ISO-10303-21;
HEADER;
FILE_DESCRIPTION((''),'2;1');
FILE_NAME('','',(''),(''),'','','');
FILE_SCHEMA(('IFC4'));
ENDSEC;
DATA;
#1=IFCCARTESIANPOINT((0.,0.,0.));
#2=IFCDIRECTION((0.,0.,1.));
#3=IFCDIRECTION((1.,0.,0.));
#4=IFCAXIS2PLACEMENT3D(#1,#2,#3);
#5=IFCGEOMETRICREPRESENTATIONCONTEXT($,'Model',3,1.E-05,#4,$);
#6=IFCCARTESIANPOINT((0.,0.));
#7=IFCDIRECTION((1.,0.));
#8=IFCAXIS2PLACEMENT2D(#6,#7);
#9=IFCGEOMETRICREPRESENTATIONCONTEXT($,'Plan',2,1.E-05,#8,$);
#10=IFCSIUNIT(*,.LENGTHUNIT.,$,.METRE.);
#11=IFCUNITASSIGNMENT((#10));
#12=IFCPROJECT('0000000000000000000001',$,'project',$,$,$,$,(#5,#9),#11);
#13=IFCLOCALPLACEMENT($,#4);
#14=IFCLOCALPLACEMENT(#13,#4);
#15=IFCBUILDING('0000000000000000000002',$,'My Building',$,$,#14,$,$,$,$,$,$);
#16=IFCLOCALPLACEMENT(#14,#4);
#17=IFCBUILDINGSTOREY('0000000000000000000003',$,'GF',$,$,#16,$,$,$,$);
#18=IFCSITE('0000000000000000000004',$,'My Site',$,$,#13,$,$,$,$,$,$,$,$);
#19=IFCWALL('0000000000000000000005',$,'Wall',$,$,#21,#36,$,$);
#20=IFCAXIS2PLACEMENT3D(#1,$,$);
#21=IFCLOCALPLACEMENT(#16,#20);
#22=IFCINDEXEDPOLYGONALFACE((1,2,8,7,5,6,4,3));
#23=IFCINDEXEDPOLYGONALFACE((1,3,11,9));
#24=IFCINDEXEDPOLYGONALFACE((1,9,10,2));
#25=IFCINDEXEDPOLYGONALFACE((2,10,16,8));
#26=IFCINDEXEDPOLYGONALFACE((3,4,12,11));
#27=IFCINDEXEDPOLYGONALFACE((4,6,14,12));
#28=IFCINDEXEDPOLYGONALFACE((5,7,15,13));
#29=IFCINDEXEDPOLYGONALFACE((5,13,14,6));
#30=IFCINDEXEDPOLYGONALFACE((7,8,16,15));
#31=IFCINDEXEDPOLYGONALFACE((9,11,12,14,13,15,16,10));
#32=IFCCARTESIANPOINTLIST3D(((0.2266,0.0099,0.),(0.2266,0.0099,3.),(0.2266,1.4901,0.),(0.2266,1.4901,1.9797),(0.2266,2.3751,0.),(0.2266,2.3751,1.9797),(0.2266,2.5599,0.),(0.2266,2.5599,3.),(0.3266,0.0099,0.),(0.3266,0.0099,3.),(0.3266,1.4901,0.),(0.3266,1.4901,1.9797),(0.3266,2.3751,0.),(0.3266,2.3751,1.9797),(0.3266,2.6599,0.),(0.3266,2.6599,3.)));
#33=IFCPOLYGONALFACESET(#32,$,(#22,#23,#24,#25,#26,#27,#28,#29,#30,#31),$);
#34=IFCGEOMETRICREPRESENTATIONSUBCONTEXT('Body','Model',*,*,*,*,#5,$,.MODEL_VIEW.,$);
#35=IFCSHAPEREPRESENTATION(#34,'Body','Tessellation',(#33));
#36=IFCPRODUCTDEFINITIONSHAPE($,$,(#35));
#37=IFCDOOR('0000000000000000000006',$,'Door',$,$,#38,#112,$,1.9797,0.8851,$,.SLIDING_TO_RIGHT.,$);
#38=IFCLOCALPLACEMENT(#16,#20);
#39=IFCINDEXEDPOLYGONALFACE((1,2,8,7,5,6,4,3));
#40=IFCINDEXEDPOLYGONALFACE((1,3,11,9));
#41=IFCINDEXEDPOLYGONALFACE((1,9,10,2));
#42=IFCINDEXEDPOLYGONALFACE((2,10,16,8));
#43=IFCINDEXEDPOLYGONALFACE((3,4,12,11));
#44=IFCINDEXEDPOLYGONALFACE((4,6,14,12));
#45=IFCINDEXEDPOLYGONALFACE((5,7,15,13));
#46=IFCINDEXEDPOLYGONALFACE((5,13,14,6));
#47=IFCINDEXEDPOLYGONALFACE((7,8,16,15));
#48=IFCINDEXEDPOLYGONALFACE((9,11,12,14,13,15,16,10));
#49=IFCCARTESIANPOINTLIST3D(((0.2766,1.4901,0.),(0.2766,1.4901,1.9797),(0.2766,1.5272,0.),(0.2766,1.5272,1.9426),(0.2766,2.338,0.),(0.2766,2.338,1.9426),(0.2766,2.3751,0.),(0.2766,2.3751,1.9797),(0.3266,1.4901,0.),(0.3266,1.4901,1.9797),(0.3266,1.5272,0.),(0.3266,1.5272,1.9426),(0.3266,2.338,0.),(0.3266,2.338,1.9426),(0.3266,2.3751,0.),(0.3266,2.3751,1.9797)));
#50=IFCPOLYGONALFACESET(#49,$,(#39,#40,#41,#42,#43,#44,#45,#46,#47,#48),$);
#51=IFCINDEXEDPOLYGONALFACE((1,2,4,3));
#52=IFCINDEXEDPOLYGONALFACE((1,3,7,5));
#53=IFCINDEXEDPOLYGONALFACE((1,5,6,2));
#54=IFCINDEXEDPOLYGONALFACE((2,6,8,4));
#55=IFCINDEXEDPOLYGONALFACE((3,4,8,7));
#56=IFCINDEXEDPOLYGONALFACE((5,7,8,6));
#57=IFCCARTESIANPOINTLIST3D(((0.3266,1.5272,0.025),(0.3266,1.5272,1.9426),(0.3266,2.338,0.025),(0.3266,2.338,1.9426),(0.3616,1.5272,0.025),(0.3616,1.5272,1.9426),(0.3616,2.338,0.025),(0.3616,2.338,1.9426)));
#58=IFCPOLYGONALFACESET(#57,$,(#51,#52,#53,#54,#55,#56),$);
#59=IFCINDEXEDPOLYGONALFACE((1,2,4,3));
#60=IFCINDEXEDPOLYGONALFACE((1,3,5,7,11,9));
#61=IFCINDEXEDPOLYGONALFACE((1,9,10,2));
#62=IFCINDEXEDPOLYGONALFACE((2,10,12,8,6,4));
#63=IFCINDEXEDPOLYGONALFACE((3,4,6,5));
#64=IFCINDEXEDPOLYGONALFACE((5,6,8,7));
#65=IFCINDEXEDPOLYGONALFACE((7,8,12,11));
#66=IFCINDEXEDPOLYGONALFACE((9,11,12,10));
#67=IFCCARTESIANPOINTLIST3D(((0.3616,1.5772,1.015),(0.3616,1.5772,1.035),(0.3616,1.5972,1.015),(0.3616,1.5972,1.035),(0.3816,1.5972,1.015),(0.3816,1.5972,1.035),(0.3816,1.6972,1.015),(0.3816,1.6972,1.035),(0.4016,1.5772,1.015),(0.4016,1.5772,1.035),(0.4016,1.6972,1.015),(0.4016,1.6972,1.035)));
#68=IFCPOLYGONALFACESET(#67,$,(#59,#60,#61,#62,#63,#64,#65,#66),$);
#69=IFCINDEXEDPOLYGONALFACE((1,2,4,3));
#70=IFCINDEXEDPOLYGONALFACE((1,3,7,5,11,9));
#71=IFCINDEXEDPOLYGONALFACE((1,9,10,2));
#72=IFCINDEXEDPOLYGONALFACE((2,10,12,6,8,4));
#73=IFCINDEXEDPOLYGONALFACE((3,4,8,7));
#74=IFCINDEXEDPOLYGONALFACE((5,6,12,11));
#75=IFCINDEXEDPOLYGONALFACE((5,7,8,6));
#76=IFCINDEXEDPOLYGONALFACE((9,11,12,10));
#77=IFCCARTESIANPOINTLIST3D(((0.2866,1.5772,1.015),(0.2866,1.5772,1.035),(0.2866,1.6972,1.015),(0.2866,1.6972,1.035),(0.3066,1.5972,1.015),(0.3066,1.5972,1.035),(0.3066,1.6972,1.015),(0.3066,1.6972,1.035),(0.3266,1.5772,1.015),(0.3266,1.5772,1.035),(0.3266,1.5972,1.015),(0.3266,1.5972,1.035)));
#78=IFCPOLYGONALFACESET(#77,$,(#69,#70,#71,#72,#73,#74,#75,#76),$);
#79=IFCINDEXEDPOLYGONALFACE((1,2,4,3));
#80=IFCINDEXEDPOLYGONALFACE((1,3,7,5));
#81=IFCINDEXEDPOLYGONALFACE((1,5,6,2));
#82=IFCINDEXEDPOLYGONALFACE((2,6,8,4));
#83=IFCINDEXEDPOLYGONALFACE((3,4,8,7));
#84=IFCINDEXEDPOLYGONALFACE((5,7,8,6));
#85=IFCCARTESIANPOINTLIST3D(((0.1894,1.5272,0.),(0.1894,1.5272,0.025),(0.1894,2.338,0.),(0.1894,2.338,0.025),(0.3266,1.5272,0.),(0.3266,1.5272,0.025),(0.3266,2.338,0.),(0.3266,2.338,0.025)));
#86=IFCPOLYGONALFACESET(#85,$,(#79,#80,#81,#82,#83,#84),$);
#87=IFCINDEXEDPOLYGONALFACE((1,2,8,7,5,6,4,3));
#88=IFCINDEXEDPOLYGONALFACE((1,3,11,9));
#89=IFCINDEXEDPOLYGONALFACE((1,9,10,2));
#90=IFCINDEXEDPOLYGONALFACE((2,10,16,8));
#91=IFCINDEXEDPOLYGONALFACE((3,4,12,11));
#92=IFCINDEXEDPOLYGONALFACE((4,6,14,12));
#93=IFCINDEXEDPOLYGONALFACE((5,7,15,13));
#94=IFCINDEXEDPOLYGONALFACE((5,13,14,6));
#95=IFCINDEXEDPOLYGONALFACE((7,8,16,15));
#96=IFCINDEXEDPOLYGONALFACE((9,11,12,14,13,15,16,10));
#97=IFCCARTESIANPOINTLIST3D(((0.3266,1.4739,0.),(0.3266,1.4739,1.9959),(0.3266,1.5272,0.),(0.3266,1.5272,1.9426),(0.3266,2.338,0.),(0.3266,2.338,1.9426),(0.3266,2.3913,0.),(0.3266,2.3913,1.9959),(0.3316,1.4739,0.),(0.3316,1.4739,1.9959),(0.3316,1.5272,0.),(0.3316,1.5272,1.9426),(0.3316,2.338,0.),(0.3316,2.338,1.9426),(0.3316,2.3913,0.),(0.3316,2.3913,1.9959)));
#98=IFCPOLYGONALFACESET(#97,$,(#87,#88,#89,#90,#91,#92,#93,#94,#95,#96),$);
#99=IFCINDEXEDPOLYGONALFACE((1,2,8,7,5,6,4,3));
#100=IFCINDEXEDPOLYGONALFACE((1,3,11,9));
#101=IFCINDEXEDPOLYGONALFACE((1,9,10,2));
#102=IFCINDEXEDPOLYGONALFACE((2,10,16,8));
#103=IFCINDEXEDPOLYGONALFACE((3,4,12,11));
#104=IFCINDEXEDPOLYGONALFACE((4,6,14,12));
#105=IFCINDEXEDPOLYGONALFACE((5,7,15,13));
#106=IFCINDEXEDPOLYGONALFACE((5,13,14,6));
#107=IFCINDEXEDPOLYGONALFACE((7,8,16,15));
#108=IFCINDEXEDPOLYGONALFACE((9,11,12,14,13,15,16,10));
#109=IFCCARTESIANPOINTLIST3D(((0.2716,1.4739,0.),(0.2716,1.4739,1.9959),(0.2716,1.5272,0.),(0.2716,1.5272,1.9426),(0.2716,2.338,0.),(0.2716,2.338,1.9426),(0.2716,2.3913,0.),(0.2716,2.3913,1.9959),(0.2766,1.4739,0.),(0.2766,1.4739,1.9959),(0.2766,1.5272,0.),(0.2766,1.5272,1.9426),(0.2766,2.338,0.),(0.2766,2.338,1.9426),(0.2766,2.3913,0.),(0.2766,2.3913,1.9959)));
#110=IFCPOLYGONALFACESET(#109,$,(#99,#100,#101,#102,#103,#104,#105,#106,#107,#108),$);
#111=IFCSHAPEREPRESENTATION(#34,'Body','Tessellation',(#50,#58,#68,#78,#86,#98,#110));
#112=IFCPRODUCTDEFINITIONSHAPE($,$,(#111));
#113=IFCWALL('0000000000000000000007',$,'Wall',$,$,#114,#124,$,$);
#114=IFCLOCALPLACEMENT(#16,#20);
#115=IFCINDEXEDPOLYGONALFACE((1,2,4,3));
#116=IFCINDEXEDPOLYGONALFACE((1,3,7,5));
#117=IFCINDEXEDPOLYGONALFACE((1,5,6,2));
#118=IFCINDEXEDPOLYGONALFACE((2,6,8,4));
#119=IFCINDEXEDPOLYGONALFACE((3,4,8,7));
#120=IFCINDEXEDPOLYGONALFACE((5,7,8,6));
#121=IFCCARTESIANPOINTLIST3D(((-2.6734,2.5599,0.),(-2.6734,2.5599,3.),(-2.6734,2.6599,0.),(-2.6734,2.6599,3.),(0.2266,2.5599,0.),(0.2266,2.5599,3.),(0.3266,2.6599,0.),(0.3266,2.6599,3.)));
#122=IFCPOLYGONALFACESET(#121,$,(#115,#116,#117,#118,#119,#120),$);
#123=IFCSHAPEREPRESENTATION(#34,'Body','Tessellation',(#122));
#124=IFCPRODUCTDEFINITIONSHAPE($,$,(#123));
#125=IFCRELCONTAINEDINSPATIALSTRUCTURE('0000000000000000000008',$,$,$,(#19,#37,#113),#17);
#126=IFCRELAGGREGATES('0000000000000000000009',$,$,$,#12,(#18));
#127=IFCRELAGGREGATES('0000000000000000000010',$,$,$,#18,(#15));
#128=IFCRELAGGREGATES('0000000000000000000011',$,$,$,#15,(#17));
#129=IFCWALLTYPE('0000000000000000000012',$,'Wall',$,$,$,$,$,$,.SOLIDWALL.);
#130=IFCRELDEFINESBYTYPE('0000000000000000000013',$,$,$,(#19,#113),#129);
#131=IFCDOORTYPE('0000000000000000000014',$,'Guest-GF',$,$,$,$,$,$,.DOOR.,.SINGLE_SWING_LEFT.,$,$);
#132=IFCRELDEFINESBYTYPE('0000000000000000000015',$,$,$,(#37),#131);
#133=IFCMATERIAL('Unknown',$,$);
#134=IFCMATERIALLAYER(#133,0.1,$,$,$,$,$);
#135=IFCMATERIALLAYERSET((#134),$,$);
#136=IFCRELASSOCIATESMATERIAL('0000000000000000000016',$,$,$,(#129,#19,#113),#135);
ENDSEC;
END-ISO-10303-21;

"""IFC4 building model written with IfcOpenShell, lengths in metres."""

from ifc_helpers import new_model, entity, si_unit, frame, origin_with_axes, origin_2d_with_axis, place, context, subcontext, project, spatial, line, indexed_curve, outline, extrude, shape, source, transform, mapped, material, layer, layer_set, layer_usage, type_object, type_shapes, element, fill, save


model = new_model("IFC4")

# Units and contexts
model_context = context("Model", 3, precision=1e-05, world=origin_with_axes())
plan_context = context("Plan", 2, precision=1e-05, world=origin_2d_with_axis())
body_context_1 = subcontext(model_context, "Body", "Model", "MODEL_VIEW")
body_context_2 = subcontext(plan_context, "Body", "Plan", "PLAN_VIEW")
ifc_project = project(units=[si_unit("LENGTHUNIT", "METRE")], contexts=[model_context, plan_context])

# Site, building, storey
site_placement = place(None, origin_with_axes())
site = spatial("IfcSite", under=ifc_project, at=site_placement, Name="My Site")
building_placement = place(site_placement, origin_with_axes())
building = spatial("IfcBuilding", under=site, at=building_placement, Name="My Building")
storey_placement = place(building_placement, origin_with_axes())
storey = spatial("IfcBuildingStorey", under=building, at=storey_placement, Name="GF")

# Shared definitions
ifc_material = material(Name="Unknown")

# Shared definitions
ifc_layer_1 = layer(ifc_material, 0.1)
ifc_layer_set_1 = layer_set([ifc_layer_1])
wall_type = type_object("IfcWallType", Name="Wall", PredefinedType="SOLIDWALL", material=ifc_layer_set_1)

# Wall, opening, door
ifc_layer_usage_1 = layer_usage(ifc_layer_set_1, "AXIS2", "POSITIVE", 0.0)
wall_1_placement = place(storey_placement, frame((0.3266, 0.0099, 0.0), z_axis=(0.0, 0.0, 1.0), x_axis=(0.0, 1.0, 0.0)))
wall_1 = element("IfcWall", 1, at=wall_1_placement, inside=storey, type_object=wall_type, material=ifc_layer_usage_1, Name="Wall", context=body_context_1, shape_type="SweptSolid", body=[
    extrude(outline(indexed_curve([(0.0, 0.0), (0.0, 0.1), (2.55, 0.1), (2.65, 0.0)], segments=[line(1, 2, 3, 4, 1)])), origin_with_axes(), (0.0, 0.0, 1.0), 3.0),
])
shared_shape_1 = source(origin_with_axes(), body_context_1, "Body", "SweptSolid", [
    extrude(outline(indexed_curve([(0.0, 0.0), (0.8851, 0.0), (0.8851, 1.9797), (0.0, 1.9797)], segments=[line(1, 2, 3, 4, 1)])), frame((0.0, -0.6, 0.0), z_axis=(0.0, -1.0, 0.0), x_axis=(1.0, 0.0, 0.0)), (0.0, 0.0, -1.0), 1.2),
])
opening_1_placement = place(wall_1_placement, frame((1.4802, 0.0, 0.0), z_axis=(0.0, 0.0, 1.0), x_axis=(1.0, 0.0, 0.0)))
opening_1 = element("IfcOpeningElement", 2, at=opening_1_placement, cuts=wall_1, PredefinedType="OPENING", context=body_context_1, shape_type="MappedRepresentation", body=[
    mapped(shared_shape_1, transform((0.0, 0.0, 0.0), x_axis=(1.0, 0.0, 0.0), y_axis=(0.0, 1.0, 0.0), z_axis=(0.0, 0.0, 1.0), scale=1.0)),
])
door_type_1 = type_object("IfcDoorType", Name="Guest-GF", OperationType="SINGLE_SWING_LEFT", PredefinedType="DOOR")
shared_shape_2 = source(origin_with_axes(), body_context_1, "Body", "SweptSolid", [
    extrude(outline(indexed_curve([(0.0, 0.0), (0.0, 1.9797), (0.8851, 1.9797), (0.8851, 0.0), (0.848, 0.0), (0.848, 1.9426), (0.0371, 1.9426), (0.0371, 0.0)], segments=[line(1, 2, 3, 4, 5, 6, 7, 8, 1)])), frame((0.0, 0.0, 0.0), z_axis=(0.0, -1.0, 0.0), x_axis=(1.0, 0.0, 0.0)), (0.0, 0.0, -1.0), 0.05),
    extrude(outline(indexed_curve([(0.0, 0.0), (0.8109, 0.0), (0.8109, 0.035), (0.0, 0.035)], segments=[line(1, 2, 3, 4, 1)])), frame((0.0371, -0.035, 0.025), z_axis=(0.0, 0.0, 1.0), x_axis=(1.0, 0.0, 0.0)), (0.0, 0.0, 1.0), 1.9176),
    extrude(outline(indexed_curve([(0.0, 0.0), (0.0, -0.04), (0.12, -0.04), (0.12, -0.02), (0.02, -0.02), (0.02, 0.0)], segments=[line(1, 2, 3, 4, 5, 6, 1)])), frame((0.0871, -0.035, 1.015), z_axis=(0.0, 0.0, 1.0), x_axis=(1.0, 0.0, 0.0)), (0.0, 0.0, 1.0), 0.02),
    extrude(outline(indexed_curve([(0.0, 0.0), (0.0, 0.04), (0.12, 0.04), (0.12, 0.02), (0.02, 0.02), (0.02, 0.0)], segments=[line(1, 2, 3, 4, 5, 6, 1)])), frame((0.0871, 0.0, 1.015), z_axis=(0.0, 0.0, 1.0), x_axis=(1.0, 0.0, 0.0)), (0.0, 0.0, 1.0), 0.02),
    extrude(outline(indexed_curve([(0.0, 0.0), (0.8109, 0.0), (0.8109, 0.1372), (0.0, 0.1372)], segments=[line(1, 2, 3, 4, 1)])), frame((0.0371, 0.0, 0.0), z_axis=(0.0, 0.0, 1.0), x_axis=(1.0, 0.0, 0.0)), (0.0, 0.0, 1.0), 0.025),
    extrude(outline(indexed_curve([(0.0, 0.0), (0.0, 1.9959), (0.9174, 1.9959), (0.9174, 0.0), (0.8641, 0.0), (0.8641, 1.9426), (0.0532, 1.9426), (0.0532, 0.0)], segments=[line(1, 2, 3, 4, 5, 6, 7, 8, 1)])), frame((-0.0162, -0.005, 0.0), z_axis=(0.0, -1.0, 0.0), x_axis=(1.0, 0.0, 0.0)), (0.0, 0.0, -1.0), 0.005),
    extrude(outline(indexed_curve([(0.0, 0.0), (0.0, 1.9959), (0.9174, 1.9959), (0.9174, 0.0), (0.8641, 0.0), (0.8641, 1.9426), (0.0532, 1.9426), (0.0532, 0.0)], segments=[line(1, 2, 3, 4, 5, 6, 7, 8, 1)])), frame((-0.0162, 0.05, 0.0), z_axis=(0.0, -1.0, 0.0), x_axis=(1.0, 0.0, 0.0)), (0.0, 0.0, -1.0), 0.005),
])
shared_shape_3 = source(origin_with_axes(), body_context_2, "Body", "Curve2D", [
    entity("IfcIndexedPolyCurve", entity("IfcCartesianPointList2D", [[0.0, 0.0], [0.0371, 0.0], [0.0371, 0.05], [0.0, 0.05]]), [entity("IfcLineIndex", [1, 2, 3, 4, 1])]),
    entity("IfcIndexedPolyCurve", entity("IfcCartesianPointList2D", [[0.8851, 0.0], [0.848, 0.0], [0.848, 0.05], [0.8851, 0.05]]), [entity("IfcLineIndex", [1, 2, 3, 4, 1])]),
    entity("IfcIndexedPolyCurve", entity("IfcCartesianPointList2D", [[1.2534, -0.035], [0.4425, -0.035], [0.4425, 0.0], [1.2534, 0.0]]), [entity("IfcLineIndex", [1, 2, 3, 4, 1])]),
])
type_shapes(door_type_1, [shared_shape_2, shared_shape_3])
door_1_placement = place(opening_1_placement, frame((0.0, 0.0, 0.0), z_axis=(0.0, 0.0, 1.0), x_axis=(1.0, 0.0, 0.0)))
door_1 = element("IfcDoor", 3, at=door_1_placement, inside=storey, type_object=door_type_1, Name="Door", OperationType="SLIDING_TO_RIGHT", OverallHeight=1.9797, OverallWidth=0.8851, shapes=[
    shape(body_context_1, "Body", "MappedRepresentation", [mapped(shared_shape_2, transform((0.0, 0.0, 0.0), x_axis=(1.0, 0.0, 0.0), y_axis=(0.0, 1.0, 0.0), z_axis=(0.0, 0.0, 1.0), scale=1.0))]),
    shape(body_context_2, "Body", "MappedRepresentation", [mapped(shared_shape_3, transform((0.0, 0.0, 0.0), x_axis=(1.0, 0.0, 0.0), y_axis=(0.0, 1.0, 0.0), z_axis=(0.0, 0.0, 1.0), scale=1.0))]),
])
fill(opening_1, door_1)

# Wall
ifc_layer_usage_2 = layer_usage(ifc_layer_set_1, "AXIS2", "POSITIVE", 0.0)
wall_2_placement = place(storey_placement, frame((0.3266, 2.6599, 0.0), z_axis=(0.0, 0.0, 1.0), x_axis=(-1.0, 0.0, 0.0)))
element("IfcWall", 4, at=wall_2_placement, inside=storey, type_object=wall_type, material=ifc_layer_usage_2, Name="Wall", context=body_context_1, shape_type="SweptSolid", body=[
    extrude(outline(indexed_curve([(0.0, 0.0), (0.1, 0.1), (3.0, 0.1), (3.0, 0.0)], segments=[line(1, 2, 3, 4, 1)])), origin_with_axes(), (0.0, 0.0, 1.0), 3.0),
])

save(model, "model.ifc")
